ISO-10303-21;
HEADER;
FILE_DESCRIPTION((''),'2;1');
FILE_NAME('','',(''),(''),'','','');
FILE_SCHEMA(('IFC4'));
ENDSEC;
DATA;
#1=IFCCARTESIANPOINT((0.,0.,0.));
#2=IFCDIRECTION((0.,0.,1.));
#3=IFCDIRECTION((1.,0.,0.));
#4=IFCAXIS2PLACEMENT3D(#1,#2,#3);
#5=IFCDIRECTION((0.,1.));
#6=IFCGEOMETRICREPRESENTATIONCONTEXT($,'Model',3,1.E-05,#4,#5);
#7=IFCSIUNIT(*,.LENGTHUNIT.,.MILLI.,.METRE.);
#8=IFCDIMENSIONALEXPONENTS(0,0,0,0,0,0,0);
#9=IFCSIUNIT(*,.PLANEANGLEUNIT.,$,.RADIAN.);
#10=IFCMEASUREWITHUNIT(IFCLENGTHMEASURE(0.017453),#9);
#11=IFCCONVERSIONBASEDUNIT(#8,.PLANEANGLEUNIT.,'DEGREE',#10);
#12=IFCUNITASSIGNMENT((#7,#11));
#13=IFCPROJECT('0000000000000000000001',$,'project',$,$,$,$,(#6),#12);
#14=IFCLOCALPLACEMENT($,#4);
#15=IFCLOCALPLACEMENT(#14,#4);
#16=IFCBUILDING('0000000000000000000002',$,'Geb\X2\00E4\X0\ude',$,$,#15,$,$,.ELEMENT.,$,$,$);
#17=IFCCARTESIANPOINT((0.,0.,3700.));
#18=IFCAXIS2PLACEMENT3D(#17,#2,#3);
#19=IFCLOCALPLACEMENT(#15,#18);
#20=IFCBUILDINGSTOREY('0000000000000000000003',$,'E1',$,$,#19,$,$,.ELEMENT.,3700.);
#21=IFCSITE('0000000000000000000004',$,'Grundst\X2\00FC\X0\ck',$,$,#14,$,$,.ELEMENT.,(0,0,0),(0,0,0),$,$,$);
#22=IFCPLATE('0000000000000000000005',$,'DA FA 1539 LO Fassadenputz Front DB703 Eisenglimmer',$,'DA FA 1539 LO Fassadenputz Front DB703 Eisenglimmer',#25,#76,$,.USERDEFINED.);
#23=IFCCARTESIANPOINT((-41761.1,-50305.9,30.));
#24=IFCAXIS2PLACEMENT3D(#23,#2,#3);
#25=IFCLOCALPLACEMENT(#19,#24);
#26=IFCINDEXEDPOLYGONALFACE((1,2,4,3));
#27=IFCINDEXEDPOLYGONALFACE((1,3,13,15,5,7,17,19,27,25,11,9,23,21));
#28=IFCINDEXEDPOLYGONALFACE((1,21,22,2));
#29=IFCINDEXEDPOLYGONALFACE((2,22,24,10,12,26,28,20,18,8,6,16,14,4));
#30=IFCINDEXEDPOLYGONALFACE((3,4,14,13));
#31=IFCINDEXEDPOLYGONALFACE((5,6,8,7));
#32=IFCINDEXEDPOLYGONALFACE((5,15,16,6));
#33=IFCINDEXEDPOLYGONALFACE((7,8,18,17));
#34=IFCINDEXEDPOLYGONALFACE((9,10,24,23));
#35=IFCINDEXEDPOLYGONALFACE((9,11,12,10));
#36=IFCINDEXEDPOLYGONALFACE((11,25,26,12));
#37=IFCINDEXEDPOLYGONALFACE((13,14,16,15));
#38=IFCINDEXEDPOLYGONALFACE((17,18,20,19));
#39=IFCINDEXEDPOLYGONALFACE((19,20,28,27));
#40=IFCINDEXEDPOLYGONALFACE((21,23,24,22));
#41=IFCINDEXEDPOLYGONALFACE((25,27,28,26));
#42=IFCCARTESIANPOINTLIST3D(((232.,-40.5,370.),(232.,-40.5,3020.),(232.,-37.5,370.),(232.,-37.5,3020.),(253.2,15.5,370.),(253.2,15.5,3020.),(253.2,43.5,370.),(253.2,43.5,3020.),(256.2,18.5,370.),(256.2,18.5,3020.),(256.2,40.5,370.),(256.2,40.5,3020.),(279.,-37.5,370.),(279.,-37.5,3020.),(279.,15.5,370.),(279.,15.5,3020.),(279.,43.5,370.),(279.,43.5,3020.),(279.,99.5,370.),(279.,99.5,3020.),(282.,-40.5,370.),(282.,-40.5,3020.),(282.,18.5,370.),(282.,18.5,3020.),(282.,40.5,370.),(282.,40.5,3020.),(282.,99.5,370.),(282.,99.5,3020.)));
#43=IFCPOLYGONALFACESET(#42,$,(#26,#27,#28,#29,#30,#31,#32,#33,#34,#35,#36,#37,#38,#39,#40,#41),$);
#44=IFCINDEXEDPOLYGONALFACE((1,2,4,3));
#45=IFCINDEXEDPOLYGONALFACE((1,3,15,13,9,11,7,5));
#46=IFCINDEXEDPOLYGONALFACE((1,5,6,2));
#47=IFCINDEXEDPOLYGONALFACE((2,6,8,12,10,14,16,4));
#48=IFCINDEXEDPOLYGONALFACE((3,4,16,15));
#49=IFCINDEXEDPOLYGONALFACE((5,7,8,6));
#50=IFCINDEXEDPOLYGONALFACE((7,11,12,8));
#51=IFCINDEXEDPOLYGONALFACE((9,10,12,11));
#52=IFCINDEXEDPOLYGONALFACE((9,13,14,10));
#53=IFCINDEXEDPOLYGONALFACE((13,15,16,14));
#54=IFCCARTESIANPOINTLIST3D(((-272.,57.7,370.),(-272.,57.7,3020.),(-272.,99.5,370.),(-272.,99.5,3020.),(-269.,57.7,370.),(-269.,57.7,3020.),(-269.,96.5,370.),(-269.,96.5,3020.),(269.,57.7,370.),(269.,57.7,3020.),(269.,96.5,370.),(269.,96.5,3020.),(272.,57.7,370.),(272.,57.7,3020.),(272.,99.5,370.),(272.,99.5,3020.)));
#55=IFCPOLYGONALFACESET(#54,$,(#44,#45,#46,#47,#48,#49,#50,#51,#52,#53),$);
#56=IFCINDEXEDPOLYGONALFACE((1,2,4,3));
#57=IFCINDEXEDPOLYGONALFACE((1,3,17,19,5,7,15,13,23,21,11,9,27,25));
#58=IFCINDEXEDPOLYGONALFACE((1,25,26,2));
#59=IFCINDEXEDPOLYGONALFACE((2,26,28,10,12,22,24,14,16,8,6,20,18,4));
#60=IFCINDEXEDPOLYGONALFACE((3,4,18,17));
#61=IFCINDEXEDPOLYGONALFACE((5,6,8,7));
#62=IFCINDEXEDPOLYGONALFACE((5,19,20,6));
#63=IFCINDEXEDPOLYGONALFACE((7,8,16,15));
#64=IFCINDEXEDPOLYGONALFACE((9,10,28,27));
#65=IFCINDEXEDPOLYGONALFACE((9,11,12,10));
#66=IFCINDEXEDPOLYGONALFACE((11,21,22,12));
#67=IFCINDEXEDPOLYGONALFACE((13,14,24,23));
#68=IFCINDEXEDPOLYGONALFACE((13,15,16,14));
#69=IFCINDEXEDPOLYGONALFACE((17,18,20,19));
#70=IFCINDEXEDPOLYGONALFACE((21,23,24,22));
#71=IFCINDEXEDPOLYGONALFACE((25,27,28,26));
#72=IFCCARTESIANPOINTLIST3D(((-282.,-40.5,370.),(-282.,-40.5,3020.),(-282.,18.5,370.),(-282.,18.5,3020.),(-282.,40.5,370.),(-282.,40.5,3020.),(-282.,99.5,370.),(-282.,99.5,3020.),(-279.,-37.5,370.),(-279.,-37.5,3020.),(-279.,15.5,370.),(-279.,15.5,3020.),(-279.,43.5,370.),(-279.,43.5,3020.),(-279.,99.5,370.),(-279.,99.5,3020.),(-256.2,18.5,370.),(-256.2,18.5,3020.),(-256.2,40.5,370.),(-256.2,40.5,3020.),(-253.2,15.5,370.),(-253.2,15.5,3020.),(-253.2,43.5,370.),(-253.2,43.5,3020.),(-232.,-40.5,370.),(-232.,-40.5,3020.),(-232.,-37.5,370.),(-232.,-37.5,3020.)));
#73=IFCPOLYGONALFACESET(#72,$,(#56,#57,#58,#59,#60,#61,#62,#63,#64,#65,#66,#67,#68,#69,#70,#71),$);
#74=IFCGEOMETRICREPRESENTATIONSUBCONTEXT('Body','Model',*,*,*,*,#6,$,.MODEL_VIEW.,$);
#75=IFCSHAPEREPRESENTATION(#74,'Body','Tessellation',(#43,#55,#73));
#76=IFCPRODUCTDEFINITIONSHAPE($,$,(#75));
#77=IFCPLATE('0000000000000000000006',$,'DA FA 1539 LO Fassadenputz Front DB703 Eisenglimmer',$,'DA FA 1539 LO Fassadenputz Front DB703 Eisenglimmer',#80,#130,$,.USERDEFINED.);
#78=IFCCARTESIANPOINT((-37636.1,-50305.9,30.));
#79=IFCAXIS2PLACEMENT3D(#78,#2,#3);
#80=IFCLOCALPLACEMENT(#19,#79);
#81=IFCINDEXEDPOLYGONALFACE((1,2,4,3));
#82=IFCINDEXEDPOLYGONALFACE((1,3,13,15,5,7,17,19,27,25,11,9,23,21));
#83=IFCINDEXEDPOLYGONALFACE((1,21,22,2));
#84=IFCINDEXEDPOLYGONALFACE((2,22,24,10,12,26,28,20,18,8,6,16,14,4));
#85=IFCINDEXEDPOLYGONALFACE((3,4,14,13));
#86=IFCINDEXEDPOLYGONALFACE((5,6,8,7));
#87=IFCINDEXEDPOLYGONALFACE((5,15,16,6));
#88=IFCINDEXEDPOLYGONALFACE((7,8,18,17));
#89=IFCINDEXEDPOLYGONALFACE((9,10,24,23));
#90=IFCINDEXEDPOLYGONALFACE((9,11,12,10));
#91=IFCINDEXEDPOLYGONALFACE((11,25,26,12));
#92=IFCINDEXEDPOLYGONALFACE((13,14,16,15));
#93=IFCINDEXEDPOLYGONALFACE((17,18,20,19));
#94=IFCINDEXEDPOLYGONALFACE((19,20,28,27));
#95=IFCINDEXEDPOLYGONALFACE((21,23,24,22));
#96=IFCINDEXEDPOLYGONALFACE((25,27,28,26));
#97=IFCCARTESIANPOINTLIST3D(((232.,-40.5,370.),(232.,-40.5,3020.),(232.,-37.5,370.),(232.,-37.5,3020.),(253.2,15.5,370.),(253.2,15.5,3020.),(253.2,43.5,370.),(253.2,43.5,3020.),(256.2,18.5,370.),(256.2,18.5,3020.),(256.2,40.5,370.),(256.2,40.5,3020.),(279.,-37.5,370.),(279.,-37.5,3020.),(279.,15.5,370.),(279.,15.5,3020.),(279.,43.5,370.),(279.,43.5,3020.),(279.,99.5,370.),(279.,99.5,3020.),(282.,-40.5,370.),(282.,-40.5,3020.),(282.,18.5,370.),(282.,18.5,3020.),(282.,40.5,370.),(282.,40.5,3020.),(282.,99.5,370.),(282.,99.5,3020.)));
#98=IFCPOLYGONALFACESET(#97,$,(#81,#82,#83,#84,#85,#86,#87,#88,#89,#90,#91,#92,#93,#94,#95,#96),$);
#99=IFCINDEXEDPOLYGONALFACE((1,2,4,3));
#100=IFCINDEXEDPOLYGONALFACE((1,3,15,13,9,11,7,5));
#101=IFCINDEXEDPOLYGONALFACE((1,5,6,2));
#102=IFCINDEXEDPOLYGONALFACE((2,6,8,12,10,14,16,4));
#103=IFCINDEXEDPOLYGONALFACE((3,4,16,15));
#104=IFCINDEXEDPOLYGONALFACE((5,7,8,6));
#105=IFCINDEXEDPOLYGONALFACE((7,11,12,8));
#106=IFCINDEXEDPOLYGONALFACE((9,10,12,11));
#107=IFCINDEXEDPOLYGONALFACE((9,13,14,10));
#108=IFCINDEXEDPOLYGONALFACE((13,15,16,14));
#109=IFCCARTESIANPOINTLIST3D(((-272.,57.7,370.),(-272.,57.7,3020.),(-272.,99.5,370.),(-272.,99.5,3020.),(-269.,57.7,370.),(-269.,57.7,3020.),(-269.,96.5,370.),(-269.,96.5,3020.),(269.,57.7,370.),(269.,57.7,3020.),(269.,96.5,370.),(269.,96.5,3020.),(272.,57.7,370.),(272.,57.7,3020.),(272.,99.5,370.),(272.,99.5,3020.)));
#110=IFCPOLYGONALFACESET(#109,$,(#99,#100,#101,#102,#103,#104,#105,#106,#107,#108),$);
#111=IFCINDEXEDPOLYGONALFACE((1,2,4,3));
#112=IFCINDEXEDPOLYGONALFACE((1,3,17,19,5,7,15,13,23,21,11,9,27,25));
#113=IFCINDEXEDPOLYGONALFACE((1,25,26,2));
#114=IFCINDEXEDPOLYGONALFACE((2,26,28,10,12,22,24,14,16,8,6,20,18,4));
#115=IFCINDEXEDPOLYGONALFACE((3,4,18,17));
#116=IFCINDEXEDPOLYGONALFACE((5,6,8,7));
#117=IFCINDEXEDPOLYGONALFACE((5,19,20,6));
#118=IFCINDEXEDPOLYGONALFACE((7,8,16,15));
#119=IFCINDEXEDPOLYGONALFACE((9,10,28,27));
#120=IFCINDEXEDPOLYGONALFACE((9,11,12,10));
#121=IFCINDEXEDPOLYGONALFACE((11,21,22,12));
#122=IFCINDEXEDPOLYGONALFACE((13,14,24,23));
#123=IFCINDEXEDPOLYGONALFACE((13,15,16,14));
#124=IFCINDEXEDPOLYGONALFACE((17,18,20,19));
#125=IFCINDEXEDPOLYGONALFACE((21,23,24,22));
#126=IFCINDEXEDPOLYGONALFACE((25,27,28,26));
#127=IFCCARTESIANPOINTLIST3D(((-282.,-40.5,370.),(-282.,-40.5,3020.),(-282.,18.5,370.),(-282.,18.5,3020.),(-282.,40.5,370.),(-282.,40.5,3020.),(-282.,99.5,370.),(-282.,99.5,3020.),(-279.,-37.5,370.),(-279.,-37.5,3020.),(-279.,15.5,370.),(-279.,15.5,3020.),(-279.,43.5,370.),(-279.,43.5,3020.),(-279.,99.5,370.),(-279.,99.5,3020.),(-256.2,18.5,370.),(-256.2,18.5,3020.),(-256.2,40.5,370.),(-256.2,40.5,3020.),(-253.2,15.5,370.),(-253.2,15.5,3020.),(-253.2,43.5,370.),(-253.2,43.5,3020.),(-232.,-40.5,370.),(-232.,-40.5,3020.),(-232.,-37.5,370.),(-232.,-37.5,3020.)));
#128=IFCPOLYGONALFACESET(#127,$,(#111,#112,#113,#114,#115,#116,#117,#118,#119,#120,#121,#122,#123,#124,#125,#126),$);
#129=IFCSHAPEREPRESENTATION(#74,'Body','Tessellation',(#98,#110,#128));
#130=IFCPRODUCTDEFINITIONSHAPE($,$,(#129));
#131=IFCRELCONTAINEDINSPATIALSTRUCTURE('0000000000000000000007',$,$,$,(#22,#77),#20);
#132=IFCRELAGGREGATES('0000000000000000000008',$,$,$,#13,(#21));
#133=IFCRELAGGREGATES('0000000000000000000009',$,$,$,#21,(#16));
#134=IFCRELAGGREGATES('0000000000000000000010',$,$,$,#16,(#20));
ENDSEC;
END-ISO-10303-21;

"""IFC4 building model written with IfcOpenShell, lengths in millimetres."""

from ifc_helpers import new_model, entity, si_unit, converted_unit, direction, frame, origin_with_axes, place, context, subcontext, project, spatial, line, indexed_curve, outline, extrude, source, transform, mapped, element, save


model = new_model("IFC4")

# Units and contexts
model_context = context("Model", 3, precision=1e-05, world=origin_with_axes(), true_north=direction((0.0, 1.0)))
body_context = subcontext(model_context, "Body", "Model", "MODEL_VIEW")
ifc_project = project(units=[si_unit("LENGTHUNIT", "METRE", prefix="MILLI"), converted_unit("PLANEANGLEUNIT", "DEGREE", entity("IfcLengthMeasure", 0.017453), si_unit("PLANEANGLEUNIT", "RADIAN"), dimensions=[0, 0, 0, 0, 0, 0, 0])], contexts=[model_context])

# Site, building, storey
site_placement = place(None, origin_with_axes())
site = spatial("IfcSite", under=ifc_project, at=site_placement, Name="Grundstück", CompositionType="ELEMENT", RefLatitude=(0, 0, 0), RefLongitude=(0, 0, 0))
building_placement = place(site_placement, origin_with_axes())
building = spatial("IfcBuilding", under=site, at=building_placement, Name="Gebäude", CompositionType="ELEMENT")
storey_placement = place(building_placement, frame((0.0, 0.0, 3700.0), z_axis=(0.0, 0.0, 1.0), x_axis=(1.0, 0.0, 0.0)))
storey = spatial("IfcBuildingStorey", under=building, at=storey_placement, Name="E1", CompositionType="ELEMENT", Elevation=3700.0)

# Plates
shared_shape_1 = source(origin_with_axes(), body_context, "Body", "SweptSolid", [
    extrude(outline(indexed_curve([(282.0, 99.5), (282.0, 40.5), (256.2, 40.5), (256.2, 18.5), (282.0, 18.5), (282.0, -40.5), (232.0, -40.5), (232.0, -37.5), (279.0, -37.5), (279.0, 15.5), (253.2, 15.5), (253.2, 43.5), (279.0, 43.5), (279.0, 99.5)], segments=[line(1, 2), line(2, 3), line(3, 4), line(4, 5), line(5, 6), line(6, 7), line(7, 8), line(8, 9), line(9, 10), line(10, 11), line(11, 12), line(12, 13), line(13, 14), line(14, 1)])), frame((0.0, 0.0, 370.0), z_axis=(0.0, 0.0, 1.0), x_axis=(1.0, 0.0, 0.0)), (0.0, 0.0, 1.0), 2650.0),
    extrude(outline(indexed_curve([(272.0, 99.5), (272.0, 57.7), (269.0, 57.7), (269.0, 96.5), (-269.0, 96.5), (-269.0, 57.7), (-272.0, 57.7), (-272.0, 99.5)], segments=[line(1, 2), line(2, 3), line(3, 4), line(4, 5), line(5, 6), line(6, 7), line(7, 8), line(8, 1)])), frame((0.0, 0.0, 370.0), z_axis=(0.0, 0.0, 1.0), x_axis=(1.0, 0.0, 0.0)), (0.0, 0.0, 1.0), 2650.0),
    extrude(outline(indexed_curve([(-282.0, 99.5), (-282.0, 40.5), (-256.2, 40.5), (-256.2, 18.5), (-282.0, 18.5), (-282.0, -40.5), (-232.0, -40.5), (-232.0, -37.5), (-279.0, -37.5), (-279.0, 15.5), (-253.2, 15.5), (-253.2, 43.5), (-279.0, 43.5), (-279.0, 99.5)], segments=[line(1, 2), line(2, 3), line(3, 4), line(4, 5), line(5, 6), line(6, 7), line(7, 8), line(8, 9), line(9, 10), line(10, 11), line(11, 12), line(12, 13), line(13, 14), line(14, 1)])), frame((0.0, 0.0, 370.0), z_axis=(0.0, 0.0, 1.0), x_axis=(1.0, 0.0, 0.0)), (0.0, 0.0, 1.0), 2650.0),
])
for number, where, z_axis, x_axis, name in (
    (1, (-41761.1, -50305.9, 30.0), (0.0, 0.0, 1.0), (1.0, 0.0, 0.0), "DA FA 1539 LO Fassadenputz Front DB703 Eisenglimmer"),
    (2, (-37636.1, -50305.9, 30.0), (0.0, 0.0, 1.0), (1.0, 0.0, 0.0), "DA FA 1539 LO Fassadenputz Front DB703 Eisenglimmer"),
):
    element("IfcPlate", number, at=place(storey_placement, frame(where, z_axis=z_axis, x_axis=x_axis)), inside=storey, Name=name, ObjectType="DA FA 1539 LO Fassadenputz Front DB703 Eisenglimmer", PredefinedType="USERDEFINED", context=body_context, shape_type="MappedRepresentation", body=[
        mapped(shared_shape_1, transform((0.0, 0.0, 0.0), x_axis=(1.0, 0.0, 0.0), y_axis=(0.0, 1.0, 0.0), z_axis=(0.0, 0.0, 1.0), scale=1.0)),
    ])

save(model, "model.ifc")
